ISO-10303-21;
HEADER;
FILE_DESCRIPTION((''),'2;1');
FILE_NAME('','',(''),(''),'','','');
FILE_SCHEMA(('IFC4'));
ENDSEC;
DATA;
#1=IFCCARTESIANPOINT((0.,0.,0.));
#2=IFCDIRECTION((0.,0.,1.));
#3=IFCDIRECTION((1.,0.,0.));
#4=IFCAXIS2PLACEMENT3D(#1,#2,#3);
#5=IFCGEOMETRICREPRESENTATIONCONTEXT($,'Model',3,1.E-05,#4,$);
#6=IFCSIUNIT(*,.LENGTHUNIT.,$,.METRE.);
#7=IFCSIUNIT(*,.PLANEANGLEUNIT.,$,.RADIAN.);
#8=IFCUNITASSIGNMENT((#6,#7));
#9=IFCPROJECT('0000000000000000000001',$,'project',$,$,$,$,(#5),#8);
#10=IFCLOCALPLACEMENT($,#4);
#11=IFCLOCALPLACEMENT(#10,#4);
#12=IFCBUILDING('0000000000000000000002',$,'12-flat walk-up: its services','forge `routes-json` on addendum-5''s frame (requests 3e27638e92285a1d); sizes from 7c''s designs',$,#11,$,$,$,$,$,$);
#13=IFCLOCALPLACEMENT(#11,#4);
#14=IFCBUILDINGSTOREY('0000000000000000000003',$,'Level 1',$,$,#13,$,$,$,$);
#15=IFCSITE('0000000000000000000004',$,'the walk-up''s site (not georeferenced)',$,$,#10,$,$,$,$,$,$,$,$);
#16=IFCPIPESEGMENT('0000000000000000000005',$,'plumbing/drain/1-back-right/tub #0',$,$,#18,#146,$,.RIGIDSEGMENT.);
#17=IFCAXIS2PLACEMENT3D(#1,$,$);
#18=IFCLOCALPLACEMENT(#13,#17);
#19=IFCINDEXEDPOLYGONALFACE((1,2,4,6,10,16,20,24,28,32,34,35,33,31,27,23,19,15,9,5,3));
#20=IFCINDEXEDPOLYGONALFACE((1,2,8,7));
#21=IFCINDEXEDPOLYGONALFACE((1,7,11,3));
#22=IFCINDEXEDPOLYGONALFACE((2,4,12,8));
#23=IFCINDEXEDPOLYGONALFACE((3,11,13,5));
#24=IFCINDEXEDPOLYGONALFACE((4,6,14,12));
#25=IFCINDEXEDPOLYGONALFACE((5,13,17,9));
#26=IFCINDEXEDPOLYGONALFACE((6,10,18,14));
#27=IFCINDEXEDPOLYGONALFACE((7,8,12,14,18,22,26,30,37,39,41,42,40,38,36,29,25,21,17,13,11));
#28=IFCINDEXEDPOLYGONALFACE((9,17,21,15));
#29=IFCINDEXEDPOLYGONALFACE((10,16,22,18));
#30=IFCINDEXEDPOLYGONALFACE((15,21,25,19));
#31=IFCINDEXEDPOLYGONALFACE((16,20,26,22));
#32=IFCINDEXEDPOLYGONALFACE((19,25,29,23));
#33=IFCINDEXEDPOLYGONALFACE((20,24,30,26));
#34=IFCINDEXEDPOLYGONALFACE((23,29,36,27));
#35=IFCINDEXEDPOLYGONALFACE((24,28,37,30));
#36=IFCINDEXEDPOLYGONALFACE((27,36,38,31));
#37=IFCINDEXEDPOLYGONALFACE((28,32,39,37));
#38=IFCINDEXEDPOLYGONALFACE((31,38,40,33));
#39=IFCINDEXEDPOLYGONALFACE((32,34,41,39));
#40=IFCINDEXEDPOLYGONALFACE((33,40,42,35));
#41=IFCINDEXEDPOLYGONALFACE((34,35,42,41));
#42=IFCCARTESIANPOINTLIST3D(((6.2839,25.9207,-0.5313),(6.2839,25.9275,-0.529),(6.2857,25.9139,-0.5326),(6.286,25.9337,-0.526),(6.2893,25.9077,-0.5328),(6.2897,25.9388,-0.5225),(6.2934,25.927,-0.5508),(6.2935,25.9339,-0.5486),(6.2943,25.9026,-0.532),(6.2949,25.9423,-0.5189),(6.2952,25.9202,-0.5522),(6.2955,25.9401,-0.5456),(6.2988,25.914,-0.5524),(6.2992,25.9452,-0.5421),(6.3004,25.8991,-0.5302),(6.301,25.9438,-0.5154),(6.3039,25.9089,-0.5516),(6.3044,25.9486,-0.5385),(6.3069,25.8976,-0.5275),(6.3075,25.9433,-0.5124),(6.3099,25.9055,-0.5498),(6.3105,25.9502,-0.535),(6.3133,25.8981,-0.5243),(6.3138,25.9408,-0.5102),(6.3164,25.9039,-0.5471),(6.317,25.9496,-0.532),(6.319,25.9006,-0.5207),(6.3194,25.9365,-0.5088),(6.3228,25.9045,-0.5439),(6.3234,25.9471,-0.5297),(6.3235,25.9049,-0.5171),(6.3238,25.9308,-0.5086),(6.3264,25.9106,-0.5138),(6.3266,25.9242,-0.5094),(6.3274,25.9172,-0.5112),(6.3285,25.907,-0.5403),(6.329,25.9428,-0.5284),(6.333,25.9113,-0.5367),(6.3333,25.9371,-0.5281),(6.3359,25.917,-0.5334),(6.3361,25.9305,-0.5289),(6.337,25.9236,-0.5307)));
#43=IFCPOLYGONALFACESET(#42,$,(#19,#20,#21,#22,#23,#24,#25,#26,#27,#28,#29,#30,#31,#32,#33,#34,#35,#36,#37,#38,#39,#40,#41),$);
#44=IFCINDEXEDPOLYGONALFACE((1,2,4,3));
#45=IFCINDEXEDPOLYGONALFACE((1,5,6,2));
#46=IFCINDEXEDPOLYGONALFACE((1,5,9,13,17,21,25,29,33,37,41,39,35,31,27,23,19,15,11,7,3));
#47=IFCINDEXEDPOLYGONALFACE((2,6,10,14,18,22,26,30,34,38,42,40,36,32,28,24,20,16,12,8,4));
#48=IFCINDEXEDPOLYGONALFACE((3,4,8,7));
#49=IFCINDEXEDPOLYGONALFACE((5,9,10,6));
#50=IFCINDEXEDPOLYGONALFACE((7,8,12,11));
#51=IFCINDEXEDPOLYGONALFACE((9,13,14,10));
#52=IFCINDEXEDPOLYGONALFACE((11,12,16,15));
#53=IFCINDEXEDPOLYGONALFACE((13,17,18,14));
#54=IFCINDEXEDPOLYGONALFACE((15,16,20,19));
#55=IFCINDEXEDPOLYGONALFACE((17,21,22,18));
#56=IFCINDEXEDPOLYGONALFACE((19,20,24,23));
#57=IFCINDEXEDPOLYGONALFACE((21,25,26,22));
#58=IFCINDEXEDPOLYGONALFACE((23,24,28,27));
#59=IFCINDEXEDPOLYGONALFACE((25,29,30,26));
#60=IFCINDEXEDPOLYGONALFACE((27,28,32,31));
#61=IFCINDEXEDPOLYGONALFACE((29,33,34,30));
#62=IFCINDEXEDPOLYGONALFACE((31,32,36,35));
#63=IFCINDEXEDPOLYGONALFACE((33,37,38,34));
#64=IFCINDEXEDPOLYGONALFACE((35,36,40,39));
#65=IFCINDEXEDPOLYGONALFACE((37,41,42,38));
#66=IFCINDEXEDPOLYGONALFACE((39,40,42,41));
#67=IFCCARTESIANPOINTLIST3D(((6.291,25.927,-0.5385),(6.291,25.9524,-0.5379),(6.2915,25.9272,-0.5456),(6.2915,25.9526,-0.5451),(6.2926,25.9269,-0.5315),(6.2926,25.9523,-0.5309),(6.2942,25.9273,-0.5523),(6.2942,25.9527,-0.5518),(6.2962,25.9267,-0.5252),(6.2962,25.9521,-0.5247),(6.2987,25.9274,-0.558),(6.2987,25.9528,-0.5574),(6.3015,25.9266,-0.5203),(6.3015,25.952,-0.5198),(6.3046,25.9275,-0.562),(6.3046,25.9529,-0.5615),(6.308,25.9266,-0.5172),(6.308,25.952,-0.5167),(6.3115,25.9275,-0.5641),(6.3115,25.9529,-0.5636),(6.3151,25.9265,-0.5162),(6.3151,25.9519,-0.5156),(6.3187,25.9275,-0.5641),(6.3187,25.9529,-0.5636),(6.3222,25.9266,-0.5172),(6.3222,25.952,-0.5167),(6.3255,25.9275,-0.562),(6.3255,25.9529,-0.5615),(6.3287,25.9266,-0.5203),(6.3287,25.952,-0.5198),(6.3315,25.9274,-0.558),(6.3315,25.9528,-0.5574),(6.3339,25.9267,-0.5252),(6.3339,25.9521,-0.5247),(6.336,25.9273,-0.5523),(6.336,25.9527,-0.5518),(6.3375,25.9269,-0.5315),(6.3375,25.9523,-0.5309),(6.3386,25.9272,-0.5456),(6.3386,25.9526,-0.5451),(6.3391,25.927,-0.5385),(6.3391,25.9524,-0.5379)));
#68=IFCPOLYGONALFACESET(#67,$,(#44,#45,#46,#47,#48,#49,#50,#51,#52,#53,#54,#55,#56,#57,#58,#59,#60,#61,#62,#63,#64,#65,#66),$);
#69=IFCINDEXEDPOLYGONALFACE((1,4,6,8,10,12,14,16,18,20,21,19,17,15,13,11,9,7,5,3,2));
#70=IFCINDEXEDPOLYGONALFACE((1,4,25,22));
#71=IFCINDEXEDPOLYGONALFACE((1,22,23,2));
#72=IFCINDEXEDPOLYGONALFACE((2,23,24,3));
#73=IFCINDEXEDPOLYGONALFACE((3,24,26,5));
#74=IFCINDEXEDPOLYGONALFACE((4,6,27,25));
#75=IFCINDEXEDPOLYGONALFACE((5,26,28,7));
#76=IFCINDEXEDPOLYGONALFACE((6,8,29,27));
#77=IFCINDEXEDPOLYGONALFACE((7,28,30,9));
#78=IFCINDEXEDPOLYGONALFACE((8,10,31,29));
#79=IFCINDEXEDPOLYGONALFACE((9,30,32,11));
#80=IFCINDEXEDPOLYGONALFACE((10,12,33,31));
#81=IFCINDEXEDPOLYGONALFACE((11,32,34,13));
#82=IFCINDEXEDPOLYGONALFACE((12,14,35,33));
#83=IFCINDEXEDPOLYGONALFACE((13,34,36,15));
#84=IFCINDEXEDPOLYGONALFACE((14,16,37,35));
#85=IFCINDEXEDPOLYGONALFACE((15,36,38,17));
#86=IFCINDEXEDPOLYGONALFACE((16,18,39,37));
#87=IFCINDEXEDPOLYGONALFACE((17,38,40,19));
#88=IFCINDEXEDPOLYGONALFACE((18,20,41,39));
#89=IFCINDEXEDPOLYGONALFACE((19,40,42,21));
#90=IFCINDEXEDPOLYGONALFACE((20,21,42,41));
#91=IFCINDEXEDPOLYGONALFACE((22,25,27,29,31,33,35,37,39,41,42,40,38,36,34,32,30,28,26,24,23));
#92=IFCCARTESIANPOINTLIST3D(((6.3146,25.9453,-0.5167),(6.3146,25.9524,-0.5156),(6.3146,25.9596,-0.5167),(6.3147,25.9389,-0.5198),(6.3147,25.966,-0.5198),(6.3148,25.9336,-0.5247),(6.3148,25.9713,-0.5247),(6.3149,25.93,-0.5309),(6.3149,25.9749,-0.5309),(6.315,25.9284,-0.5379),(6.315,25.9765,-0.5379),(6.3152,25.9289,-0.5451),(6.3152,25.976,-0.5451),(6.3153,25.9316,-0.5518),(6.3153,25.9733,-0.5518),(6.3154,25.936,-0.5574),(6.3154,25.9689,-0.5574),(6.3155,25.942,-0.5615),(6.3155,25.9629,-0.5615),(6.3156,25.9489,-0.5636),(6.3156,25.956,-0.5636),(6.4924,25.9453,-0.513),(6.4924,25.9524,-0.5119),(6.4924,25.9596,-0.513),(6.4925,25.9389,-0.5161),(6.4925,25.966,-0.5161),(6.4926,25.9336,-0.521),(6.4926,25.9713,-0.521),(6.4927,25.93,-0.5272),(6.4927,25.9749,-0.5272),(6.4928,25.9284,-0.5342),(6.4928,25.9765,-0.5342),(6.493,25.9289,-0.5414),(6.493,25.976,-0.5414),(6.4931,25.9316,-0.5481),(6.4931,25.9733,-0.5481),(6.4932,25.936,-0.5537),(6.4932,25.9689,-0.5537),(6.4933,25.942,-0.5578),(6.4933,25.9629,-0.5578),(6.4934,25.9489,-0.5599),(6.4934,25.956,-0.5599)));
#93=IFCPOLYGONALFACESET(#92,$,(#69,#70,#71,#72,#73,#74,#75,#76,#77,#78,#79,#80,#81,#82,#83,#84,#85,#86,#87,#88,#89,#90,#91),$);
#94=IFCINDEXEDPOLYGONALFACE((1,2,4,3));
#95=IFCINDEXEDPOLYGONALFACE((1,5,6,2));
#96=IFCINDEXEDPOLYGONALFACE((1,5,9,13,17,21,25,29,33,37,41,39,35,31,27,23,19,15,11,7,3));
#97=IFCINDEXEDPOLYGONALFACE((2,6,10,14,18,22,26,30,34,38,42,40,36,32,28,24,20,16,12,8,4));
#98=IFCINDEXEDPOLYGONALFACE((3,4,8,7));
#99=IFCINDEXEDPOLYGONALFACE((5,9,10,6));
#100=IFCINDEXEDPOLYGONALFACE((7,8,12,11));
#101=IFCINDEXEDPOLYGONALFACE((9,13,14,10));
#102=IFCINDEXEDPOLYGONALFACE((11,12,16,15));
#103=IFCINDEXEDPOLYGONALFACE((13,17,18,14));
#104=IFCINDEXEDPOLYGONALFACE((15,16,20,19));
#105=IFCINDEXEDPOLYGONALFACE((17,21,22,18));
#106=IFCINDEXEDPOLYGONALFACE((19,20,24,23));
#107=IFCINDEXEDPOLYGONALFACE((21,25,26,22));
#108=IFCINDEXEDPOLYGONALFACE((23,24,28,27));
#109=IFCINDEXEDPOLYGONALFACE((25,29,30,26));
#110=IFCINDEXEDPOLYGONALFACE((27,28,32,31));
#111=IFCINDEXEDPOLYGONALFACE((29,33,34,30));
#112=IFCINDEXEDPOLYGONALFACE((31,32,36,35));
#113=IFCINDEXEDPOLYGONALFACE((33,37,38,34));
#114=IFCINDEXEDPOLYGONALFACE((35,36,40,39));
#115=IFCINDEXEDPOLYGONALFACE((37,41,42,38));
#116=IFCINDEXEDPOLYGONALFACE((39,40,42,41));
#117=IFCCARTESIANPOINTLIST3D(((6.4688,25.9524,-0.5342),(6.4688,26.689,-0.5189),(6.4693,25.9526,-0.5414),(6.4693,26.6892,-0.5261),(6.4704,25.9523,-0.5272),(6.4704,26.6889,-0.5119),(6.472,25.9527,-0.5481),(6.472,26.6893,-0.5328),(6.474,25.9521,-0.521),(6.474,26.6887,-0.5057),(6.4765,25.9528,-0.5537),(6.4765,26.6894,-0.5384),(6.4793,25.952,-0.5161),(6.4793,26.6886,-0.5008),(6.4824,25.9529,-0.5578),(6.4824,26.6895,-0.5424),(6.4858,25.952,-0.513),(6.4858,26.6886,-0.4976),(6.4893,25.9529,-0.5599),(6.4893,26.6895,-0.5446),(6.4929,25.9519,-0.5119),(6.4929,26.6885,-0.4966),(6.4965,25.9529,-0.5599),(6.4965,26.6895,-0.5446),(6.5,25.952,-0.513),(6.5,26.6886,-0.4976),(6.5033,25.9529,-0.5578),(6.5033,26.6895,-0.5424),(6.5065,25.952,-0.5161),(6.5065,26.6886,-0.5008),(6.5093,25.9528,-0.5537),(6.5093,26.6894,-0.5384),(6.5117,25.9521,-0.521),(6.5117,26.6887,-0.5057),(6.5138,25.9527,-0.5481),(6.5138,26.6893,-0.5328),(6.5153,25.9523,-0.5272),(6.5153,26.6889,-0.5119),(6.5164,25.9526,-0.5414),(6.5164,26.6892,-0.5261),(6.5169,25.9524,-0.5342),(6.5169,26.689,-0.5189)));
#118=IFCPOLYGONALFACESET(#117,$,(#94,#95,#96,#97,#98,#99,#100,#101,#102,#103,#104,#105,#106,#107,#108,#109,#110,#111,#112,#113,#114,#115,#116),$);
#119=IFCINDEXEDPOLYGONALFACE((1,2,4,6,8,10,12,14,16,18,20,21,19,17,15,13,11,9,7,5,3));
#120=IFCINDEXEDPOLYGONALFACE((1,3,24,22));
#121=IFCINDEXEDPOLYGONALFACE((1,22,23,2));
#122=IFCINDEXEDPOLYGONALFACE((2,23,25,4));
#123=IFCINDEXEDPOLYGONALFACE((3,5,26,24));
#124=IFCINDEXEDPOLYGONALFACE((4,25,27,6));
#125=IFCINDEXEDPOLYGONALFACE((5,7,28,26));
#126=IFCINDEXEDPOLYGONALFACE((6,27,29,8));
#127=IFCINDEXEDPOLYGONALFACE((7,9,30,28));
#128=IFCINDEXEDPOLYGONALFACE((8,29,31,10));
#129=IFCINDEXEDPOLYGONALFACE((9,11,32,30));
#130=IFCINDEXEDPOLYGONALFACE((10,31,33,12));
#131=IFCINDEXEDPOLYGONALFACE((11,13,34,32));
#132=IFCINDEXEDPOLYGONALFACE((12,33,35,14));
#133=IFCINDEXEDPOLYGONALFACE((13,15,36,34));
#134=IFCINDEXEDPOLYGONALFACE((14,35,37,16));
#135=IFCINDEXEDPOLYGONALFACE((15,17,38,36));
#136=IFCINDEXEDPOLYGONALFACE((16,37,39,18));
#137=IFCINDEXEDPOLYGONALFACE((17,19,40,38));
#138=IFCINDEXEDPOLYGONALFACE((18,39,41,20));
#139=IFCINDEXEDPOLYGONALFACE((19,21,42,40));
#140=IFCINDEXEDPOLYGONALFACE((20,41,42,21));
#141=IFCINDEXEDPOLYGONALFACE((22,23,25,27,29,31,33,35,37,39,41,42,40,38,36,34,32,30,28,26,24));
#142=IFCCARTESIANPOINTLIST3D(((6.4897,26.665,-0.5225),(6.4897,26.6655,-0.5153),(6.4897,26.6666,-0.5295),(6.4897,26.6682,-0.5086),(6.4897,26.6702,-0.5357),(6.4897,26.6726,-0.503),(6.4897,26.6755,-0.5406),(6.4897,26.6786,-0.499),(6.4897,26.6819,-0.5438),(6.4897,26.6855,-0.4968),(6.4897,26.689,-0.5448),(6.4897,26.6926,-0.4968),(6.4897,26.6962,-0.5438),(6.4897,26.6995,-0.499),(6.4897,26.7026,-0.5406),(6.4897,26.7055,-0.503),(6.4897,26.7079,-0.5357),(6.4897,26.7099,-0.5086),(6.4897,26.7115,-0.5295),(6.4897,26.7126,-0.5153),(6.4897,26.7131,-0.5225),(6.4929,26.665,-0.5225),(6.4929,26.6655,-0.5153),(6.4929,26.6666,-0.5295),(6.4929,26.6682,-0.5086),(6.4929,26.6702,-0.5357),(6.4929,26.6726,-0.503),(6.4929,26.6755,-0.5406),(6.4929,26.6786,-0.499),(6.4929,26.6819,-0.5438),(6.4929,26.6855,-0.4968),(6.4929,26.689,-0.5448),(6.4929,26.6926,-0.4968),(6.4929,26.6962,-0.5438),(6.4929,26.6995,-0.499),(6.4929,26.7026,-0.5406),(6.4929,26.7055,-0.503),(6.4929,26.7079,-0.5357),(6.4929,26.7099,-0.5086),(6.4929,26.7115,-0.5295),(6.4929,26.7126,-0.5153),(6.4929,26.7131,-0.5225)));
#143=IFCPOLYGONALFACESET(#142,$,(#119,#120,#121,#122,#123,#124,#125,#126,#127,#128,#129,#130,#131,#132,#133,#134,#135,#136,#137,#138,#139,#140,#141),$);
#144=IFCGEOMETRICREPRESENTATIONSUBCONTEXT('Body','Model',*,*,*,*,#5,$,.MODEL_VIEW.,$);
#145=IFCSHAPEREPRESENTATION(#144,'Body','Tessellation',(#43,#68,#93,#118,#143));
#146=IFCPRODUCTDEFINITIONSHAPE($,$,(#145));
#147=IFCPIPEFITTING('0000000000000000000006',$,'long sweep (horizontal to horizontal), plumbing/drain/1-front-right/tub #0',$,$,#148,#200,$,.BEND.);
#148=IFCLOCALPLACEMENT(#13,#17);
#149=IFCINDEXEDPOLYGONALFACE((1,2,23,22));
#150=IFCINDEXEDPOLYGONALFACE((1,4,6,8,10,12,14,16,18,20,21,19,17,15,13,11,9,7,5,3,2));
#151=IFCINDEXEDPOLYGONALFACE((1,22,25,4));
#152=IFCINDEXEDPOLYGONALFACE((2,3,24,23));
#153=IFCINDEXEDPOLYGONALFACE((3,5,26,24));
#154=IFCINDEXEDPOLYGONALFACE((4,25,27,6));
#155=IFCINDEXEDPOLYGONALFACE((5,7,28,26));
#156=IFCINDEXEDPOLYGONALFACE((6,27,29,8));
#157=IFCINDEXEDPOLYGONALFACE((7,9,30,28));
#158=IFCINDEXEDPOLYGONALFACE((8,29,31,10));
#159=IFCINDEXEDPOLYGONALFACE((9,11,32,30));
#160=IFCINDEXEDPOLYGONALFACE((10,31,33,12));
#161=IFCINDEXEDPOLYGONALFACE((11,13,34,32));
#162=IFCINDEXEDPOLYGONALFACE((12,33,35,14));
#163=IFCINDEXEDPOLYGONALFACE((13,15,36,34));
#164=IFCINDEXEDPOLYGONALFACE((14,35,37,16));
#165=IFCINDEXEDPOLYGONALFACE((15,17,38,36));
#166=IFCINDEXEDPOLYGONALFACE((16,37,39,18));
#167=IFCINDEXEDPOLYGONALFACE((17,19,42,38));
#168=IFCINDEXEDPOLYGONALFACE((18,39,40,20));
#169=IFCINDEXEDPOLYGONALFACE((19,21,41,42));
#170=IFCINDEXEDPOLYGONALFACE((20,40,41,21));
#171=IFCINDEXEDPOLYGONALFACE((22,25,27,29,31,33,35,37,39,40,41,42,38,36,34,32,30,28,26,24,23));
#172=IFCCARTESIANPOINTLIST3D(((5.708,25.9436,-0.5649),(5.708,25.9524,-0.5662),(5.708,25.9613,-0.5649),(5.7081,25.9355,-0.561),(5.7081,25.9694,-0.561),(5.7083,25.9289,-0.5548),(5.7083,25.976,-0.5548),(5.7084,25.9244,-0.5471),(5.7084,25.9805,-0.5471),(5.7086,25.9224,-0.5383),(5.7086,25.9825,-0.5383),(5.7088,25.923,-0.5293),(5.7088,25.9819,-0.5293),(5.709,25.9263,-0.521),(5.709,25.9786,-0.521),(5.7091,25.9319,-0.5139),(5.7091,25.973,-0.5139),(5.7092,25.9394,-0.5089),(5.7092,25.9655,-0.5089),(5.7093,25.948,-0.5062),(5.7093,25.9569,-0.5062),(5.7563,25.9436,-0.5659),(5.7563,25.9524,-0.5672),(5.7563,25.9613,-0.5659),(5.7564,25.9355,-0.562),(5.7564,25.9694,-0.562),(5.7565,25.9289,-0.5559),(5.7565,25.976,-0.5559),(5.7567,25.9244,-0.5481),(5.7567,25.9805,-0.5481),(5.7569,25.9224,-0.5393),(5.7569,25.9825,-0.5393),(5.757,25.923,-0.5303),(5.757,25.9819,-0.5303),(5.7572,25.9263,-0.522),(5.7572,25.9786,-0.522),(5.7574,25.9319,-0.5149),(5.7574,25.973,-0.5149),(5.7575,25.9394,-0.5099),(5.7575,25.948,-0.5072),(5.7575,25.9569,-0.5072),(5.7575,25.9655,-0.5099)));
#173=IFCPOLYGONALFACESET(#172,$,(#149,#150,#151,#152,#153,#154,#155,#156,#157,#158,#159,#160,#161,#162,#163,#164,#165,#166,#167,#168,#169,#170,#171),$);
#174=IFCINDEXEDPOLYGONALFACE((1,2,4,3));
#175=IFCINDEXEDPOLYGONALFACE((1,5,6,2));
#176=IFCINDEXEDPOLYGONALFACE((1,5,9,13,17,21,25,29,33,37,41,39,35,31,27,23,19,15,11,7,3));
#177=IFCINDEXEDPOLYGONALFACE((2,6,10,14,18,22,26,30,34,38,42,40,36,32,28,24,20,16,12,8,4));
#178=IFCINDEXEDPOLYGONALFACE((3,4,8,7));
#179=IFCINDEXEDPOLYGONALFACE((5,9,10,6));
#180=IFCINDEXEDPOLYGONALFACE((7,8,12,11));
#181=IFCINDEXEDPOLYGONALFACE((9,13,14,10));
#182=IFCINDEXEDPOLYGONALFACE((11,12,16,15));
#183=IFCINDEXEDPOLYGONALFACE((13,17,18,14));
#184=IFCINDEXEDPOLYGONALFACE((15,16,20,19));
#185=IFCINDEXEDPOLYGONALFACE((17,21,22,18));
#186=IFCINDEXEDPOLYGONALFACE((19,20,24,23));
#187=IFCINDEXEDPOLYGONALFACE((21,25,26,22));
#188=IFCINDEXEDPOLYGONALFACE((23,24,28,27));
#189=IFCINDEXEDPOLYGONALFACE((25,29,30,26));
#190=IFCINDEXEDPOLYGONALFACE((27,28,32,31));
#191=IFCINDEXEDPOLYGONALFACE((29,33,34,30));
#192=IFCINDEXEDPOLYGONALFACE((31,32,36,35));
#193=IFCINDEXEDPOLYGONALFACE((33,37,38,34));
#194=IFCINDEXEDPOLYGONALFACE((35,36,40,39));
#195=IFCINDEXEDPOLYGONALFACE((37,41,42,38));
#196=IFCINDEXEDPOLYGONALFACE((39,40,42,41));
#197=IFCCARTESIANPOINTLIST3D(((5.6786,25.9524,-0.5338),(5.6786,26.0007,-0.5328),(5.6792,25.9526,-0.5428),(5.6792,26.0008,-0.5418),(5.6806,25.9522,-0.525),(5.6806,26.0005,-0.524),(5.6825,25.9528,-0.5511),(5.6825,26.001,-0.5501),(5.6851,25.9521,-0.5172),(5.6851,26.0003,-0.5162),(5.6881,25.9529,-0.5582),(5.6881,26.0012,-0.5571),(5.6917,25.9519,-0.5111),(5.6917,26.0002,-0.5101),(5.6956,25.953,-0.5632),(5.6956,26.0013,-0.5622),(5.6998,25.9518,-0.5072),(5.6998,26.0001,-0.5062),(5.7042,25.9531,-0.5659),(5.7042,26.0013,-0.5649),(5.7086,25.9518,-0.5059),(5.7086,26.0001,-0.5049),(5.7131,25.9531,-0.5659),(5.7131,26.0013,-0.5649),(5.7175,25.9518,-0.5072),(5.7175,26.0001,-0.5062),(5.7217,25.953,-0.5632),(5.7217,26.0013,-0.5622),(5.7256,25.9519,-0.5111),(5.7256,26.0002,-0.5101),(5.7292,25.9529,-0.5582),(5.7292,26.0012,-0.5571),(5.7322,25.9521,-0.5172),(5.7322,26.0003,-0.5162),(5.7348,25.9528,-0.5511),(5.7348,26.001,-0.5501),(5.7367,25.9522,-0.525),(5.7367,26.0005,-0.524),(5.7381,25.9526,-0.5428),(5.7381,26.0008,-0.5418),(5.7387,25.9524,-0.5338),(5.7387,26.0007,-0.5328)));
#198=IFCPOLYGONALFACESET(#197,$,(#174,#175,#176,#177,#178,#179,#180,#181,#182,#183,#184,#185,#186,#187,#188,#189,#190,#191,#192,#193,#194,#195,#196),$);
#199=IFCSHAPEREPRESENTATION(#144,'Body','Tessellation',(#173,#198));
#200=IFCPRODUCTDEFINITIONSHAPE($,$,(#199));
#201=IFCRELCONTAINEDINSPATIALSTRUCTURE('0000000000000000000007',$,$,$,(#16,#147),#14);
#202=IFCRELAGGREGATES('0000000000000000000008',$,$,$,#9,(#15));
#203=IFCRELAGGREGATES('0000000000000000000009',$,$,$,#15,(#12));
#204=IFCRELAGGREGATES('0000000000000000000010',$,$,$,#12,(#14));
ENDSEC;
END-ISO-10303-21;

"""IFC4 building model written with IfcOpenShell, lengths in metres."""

from ifc_helpers import new_model, entity, si_unit, frame, origin_with_axes, place, context, subcontext, project, spatial, element, save


model = new_model("IFC4")

# Units and contexts
model_context = context("Model", 3, precision=1e-05, world=origin_with_axes())
body_context = subcontext(model_context, "Body", "Model", "MODEL_VIEW")
ifc_project = project(units=[si_unit("LENGTHUNIT", "METRE"), si_unit("PLANEANGLEUNIT", "RADIAN")], contexts=[model_context])

# Site, building, storey
site_placement = place(None, origin_with_axes())
site = spatial("IfcSite", under=ifc_project, at=site_placement, Name="the walk-up's site (not georeferenced)")
building_placement = place(site_placement, origin_with_axes())
building = spatial("IfcBuilding", under=site, at=building_placement, Name="12-flat walk-up: its services", Description="forge `routes-json` on addendum-5's frame (requests 3e27638e92285a1d); sizes from 7c's designs")
storey_placement = place(building_placement, origin_with_axes())
storey = spatial("IfcBuildingStorey", under=building, at=storey_placement, Name="Level 1")

# Pipe segment
pipe_segment_1_placement = place(storey_placement, frame((6.3056, 25.9207, -0.5207), z_axis=(0.0, 0.0, 1.0), x_axis=(1.0, 0.0, 0.0)))
element("IfcPipeSegment", 1, at=pipe_segment_1_placement, inside=storey, Name="plumbing/drain/1-back-right/tub #0", PredefinedType="RIGIDSEGMENT", context=body_context, shape_type="AdvancedSweptSolid", body=[
    entity("IfcSweptDiskSolid", entity("IfcPolyline", [entity("IfcCartesianPoint", [0.0, 0.0, 0.0]), entity("IfcCartesianPoint", [0.0095, 0.0064, -0.0196])]), 0.0241),
    entity("IfcSweptDiskSolid", entity("IfcPolyline", [entity("IfcCartesianPoint", [0.0095, 0.0064, -0.0196]), entity("IfcCartesianPoint", [0.0095, 0.0317, -0.019])]), 0.0241),
    entity("IfcSweptDiskSolid", entity("IfcPolyline", [entity("IfcCartesianPoint", [0.0095, 0.0317, -0.019]), entity("IfcCartesianPoint", [0.1873, 0.0317, -0.0153])]), 0.0241),
    entity("IfcSweptDiskSolid", entity("IfcPolyline", [entity("IfcCartesianPoint", [0.1873, 0.0317, -0.0153]), entity("IfcCartesianPoint", [0.1873, 0.7684, 0.0])]), 0.0241),
    entity("IfcSweptDiskSolid", entity("IfcPolyline", [entity("IfcCartesianPoint", [0.1873, 0.7684, 0.0]), entity("IfcCartesianPoint", [0.1841, 0.7684, 0.0])]), 0.0241),
])

# Pipe fitting
pipe_fitting_1_placement = place(storey_placement, frame((5.7569, 25.9524, -0.5371), z_axis=(0.0, 0.0, 1.0), x_axis=(1.0, 0.0, 0.0)))
element("IfcPipeFitting", 2, at=pipe_fitting_1_placement, inside=storey, Name="long sweep (horizontal to horizontal), plumbing/drain/1-front-right/tub #0", PredefinedType="BEND", context=body_context, shape_type="AdvancedSweptSolid", body=[
    entity("IfcSweptDiskSolid", entity("IfcPolyline", [entity("IfcCartesianPoint", [0.0, 0.0, 0.0]), entity("IfcCartesianPoint", [-0.0482, 0.0, 0.001])]), 0.0302),
    entity("IfcSweptDiskSolid", entity("IfcPolyline", [entity("IfcCartesianPoint", [-0.0482, 0.0, 0.001]), entity("IfcCartesianPoint", [-0.0482, 0.0482, 0.002])]), 0.0302),
])

save(model, "model.ifc")
